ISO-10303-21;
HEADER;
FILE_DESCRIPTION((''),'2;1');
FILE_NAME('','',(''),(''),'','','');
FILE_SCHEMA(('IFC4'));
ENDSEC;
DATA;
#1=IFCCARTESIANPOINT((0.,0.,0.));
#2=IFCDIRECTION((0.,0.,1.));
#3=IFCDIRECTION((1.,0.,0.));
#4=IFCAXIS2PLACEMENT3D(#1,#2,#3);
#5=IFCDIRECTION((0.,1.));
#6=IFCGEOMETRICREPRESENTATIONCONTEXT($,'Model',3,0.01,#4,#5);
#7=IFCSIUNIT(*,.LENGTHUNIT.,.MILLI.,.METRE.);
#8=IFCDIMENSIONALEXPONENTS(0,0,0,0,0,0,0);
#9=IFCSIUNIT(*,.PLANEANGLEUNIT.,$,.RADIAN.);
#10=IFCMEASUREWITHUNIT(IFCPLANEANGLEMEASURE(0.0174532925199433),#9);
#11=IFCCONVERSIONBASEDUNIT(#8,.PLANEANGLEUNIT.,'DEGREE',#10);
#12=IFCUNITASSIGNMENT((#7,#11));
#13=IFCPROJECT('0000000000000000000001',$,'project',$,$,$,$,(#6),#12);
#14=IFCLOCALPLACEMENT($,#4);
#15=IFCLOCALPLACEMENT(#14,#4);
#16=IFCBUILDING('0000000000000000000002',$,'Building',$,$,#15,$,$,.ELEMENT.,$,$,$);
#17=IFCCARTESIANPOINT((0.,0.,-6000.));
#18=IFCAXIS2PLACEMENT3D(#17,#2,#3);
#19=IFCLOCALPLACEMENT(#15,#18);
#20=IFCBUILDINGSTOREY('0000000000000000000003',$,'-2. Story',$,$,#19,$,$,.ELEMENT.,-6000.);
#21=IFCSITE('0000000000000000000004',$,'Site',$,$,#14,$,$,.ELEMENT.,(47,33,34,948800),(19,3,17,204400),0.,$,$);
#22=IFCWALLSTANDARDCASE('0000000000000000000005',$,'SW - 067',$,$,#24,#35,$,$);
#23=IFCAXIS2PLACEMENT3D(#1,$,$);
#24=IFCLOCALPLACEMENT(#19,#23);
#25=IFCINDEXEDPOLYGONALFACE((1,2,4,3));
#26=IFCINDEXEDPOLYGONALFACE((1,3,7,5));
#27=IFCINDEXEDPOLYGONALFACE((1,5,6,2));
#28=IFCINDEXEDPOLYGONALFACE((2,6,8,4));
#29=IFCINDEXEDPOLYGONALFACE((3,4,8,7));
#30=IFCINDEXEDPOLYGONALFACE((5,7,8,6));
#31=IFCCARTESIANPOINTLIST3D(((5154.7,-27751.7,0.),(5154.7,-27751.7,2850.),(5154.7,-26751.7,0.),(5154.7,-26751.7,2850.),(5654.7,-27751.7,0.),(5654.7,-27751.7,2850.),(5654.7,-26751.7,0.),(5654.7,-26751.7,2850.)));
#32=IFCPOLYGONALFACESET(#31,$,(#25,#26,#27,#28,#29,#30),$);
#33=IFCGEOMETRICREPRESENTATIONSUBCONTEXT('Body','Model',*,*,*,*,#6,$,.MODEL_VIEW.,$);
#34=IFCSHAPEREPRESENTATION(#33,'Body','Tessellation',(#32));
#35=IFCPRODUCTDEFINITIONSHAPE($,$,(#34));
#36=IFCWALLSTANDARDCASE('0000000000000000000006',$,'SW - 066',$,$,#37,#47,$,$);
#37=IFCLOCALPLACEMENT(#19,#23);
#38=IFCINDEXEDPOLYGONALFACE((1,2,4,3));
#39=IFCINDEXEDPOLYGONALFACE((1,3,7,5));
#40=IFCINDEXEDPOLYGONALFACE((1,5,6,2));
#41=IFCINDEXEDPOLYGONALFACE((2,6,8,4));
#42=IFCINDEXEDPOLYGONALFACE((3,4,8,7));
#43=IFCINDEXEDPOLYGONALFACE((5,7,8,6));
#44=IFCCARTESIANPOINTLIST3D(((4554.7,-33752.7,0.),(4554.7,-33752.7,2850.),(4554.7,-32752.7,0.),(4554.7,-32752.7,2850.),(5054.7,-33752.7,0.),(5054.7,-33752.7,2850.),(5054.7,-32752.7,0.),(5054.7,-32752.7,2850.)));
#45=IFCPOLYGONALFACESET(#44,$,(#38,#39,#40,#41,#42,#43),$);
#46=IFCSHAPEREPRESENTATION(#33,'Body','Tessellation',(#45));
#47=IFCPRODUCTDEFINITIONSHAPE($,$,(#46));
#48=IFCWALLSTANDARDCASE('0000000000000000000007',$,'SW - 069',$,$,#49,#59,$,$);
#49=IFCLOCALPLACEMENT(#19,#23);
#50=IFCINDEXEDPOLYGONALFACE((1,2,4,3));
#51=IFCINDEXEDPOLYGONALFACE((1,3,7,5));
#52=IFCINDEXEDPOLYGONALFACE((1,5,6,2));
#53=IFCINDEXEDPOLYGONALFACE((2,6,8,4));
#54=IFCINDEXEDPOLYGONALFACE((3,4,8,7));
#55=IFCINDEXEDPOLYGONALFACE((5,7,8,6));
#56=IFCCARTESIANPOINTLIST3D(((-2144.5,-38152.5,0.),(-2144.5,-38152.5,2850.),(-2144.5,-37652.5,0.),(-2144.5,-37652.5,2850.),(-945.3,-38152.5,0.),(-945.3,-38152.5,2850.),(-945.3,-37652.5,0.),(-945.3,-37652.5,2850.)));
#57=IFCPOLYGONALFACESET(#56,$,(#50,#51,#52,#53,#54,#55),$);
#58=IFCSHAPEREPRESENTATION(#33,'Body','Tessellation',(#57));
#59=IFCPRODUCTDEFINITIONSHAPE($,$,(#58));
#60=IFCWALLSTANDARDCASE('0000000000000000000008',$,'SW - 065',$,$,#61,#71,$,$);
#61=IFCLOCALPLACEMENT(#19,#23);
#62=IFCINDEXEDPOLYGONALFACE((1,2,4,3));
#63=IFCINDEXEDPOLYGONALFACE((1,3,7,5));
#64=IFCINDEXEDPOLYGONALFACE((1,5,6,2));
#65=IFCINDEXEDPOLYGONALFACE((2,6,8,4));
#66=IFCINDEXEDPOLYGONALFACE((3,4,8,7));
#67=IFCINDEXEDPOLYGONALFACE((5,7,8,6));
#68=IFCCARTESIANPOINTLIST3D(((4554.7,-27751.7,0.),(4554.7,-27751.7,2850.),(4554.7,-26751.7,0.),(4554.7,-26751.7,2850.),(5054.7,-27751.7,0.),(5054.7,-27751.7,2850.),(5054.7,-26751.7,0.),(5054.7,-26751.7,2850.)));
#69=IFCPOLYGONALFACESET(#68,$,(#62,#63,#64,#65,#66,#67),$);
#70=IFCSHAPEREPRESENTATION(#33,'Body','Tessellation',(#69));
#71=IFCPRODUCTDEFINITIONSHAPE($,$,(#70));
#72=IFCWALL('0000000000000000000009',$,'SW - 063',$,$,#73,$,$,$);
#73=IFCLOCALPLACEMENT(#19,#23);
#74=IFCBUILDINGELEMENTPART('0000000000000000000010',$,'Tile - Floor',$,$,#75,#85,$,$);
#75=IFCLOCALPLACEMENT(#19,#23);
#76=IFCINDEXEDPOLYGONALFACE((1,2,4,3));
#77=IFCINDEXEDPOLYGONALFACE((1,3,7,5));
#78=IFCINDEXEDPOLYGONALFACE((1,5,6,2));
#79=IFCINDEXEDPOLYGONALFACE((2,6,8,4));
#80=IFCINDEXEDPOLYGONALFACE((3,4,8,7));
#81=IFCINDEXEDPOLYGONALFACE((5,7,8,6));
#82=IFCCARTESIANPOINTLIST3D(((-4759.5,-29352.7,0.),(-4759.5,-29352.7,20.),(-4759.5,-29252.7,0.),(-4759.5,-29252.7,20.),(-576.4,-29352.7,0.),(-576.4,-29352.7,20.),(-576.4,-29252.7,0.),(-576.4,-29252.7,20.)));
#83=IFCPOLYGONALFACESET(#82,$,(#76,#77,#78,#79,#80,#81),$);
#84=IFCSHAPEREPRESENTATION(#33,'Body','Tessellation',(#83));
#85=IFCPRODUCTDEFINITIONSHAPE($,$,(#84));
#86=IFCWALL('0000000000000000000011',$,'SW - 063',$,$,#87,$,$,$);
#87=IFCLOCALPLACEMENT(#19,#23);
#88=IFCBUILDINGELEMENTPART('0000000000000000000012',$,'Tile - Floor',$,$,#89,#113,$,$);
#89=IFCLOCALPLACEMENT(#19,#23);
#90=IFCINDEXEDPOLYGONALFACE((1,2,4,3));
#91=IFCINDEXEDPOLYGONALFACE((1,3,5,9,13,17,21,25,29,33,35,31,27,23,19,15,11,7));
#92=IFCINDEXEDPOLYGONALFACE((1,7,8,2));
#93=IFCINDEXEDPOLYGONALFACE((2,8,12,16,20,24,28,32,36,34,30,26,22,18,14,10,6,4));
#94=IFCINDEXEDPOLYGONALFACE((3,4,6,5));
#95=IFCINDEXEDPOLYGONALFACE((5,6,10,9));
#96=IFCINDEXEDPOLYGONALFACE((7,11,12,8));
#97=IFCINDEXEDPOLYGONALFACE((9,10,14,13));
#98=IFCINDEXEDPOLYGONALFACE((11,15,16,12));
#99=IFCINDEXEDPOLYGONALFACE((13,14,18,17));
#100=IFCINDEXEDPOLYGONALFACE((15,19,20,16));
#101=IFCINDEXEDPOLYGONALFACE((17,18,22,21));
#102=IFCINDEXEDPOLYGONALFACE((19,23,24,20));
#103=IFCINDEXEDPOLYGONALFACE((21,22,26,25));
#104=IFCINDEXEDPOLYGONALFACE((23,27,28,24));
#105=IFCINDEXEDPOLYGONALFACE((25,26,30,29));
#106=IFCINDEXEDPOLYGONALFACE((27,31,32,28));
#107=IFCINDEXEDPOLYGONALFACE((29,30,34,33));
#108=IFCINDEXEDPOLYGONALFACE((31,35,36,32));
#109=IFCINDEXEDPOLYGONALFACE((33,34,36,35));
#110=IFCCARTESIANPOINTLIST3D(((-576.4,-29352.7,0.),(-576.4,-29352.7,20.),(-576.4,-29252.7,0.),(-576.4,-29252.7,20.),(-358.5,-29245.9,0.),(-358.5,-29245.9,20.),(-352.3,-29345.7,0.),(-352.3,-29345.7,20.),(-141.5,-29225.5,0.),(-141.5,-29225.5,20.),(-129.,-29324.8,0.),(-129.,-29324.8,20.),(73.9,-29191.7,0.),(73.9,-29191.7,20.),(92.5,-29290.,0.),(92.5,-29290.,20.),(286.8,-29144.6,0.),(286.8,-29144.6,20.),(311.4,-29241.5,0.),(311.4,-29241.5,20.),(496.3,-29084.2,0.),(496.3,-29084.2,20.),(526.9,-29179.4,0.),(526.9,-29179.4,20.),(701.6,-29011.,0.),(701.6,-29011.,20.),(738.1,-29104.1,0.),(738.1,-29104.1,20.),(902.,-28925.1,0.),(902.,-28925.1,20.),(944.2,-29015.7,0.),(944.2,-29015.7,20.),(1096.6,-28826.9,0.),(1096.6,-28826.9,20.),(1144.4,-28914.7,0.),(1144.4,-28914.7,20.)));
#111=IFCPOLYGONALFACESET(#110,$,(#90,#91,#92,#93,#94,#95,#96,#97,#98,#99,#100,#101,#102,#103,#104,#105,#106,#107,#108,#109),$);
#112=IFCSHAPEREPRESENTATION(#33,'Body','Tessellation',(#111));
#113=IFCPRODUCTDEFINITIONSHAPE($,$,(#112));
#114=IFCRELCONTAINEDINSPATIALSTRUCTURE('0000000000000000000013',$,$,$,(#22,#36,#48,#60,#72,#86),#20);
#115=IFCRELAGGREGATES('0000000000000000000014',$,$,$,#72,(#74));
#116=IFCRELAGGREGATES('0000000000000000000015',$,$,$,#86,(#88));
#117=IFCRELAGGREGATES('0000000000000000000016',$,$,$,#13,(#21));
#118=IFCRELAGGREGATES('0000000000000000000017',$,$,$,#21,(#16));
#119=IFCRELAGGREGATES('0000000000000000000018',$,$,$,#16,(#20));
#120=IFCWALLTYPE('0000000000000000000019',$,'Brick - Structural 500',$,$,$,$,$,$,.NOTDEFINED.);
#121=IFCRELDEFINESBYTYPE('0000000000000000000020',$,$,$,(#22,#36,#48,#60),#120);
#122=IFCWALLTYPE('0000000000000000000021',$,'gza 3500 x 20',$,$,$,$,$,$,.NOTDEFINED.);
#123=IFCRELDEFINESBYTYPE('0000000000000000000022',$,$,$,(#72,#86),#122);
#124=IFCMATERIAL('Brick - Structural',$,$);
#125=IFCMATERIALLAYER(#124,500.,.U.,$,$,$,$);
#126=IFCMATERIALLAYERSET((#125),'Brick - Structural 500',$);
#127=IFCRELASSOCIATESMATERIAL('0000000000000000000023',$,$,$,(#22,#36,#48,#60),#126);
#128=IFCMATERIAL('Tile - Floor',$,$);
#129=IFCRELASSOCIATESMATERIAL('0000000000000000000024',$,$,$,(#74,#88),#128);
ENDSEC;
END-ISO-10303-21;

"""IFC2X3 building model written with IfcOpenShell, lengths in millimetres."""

from ifc_helpers import new_model, entity, si_unit, converted_unit, direction, frame, origin_with_axes, place, context, subcontext, project, spatial, polyline, outline, extrude, material, layer, layer_set, layer_usage, type_object, element, aggregate, save


model = new_model("IFC2X3")

# Units and contexts
model_context = context("Model", 3, precision=0.01, world=origin_with_axes(), true_north=direction((0.0, 1.0)))
body_context = subcontext(model_context, "Body", "Model", "MODEL_VIEW")
ifc_project = project(units=[si_unit("LENGTHUNIT", "METRE", prefix="MILLI"), converted_unit("PLANEANGLEUNIT", "DEGREE", entity("IfcPlaneAngleMeasure", 0.0174532925199433), si_unit("PLANEANGLEUNIT", "RADIAN"), dimensions=[0, 0, 0, 0, 0, 0, 0])], contexts=[model_context])

# Site, building, storey
site_placement = place(None, origin_with_axes())
site = spatial("IfcSite", under=ifc_project, at=site_placement, Name="Site", CompositionType="ELEMENT", RefLatitude=(47, 33, 34, 948800), RefLongitude=(19, 3, 17, 204400), RefElevation=0.0)
building_placement = place(site_placement, origin_with_axes())
building = spatial("IfcBuilding", under=site, at=building_placement, Name="Building", CompositionType="ELEMENT")
storey_placement = place(building_placement, frame((0.0, 0.0, -6000.0), z_axis=(0.0, 0.0, 1.0), x_axis=(1.0, 0.0, 0.0)))
storey = spatial("IfcBuildingStorey", under=building, at=storey_placement, Name="-2. Story", CompositionType="ELEMENT", Elevation=-6000.0)

# Shared definitions
ifc_material_1 = material(Name="Brick - Structural")

# Walls
ifc_layer_1 = layer(ifc_material_1, 500.0, ventilated="UNKNOWN")
ifc_layer_set_1 = layer_set([ifc_layer_1], Name="Brick - Structural 500")
wall_type_1 = type_object("IfcWallType", Name="Brick - Structural 500", PredefinedType="NOTDEFINED")
ifc_layer_usage_1 = layer_usage(ifc_layer_set_1, "AXIS2", "POSITIVE", 0.0)
wall_1_placement = place(storey_placement, frame((5154.7, -26751.7, 0.0), z_axis=(0.0, 0.0, 1.0), x_axis=(0.0, -1.0, 0.0)))
element("IfcWallStandardCase", 1, at=wall_1_placement, inside=storey, type_object=wall_type_1, material=ifc_layer_usage_1, Name="SW - 067", context=body_context, shape_type="SweptSolid", body=[
    extrude(outline(polyline([(0.0, 0.0), (1000.0, 0.0), (1000.0, 500.0), (0.0, 500.0), (0.0, 0.0)])), origin_with_axes(), (0.0, 0.0, 1.0), 2850.0),
])
ifc_layer_usage_2 = layer_usage(ifc_layer_set_1, "AXIS2", "POSITIVE", 0.0)
wall_2_placement = place(storey_placement, frame((5054.7, -33752.7, 0.0), z_axis=(0.0, 0.0, 1.0), x_axis=(0.0, 1.0, 0.0)))
element("IfcWallStandardCase", 2, at=wall_2_placement, inside=storey, type_object=wall_type_1, material=ifc_layer_usage_2, Name="SW - 066", context=body_context, shape_type="SweptSolid", body=[
    extrude(outline(polyline([(0.0, 0.0), (1000.0, 0.0), (1000.0, 500.0), (0.0, 500.0), (0.0, 0.0)])), origin_with_axes(), (0.0, 0.0, 1.0), 2850.0),
])
ifc_layer_usage_3 = layer_usage(ifc_layer_set_1, "AXIS2", "NEGATIVE", 0.0)
wall_3_placement = place(storey_placement, frame((-945.3, -38152.5, 0.0), z_axis=(0.0, 0.0, 1.0), x_axis=(-1.0, 0.0, 0.0)))
element("IfcWallStandardCase", 3, at=wall_3_placement, inside=storey, type_object=wall_type_1, material=ifc_layer_usage_3, Name="SW - 069", context=body_context, shape_type="SweptSolid", body=[
    extrude(outline(polyline([(0.0, -500.0), (1199.2, -500.0), (1199.2, 0.0), (0.0, 0.0), (0.0, -500.0)])), origin_with_axes(), (0.0, 0.0, 1.0), 2850.0),
])
ifc_layer_usage_4 = layer_usage(ifc_layer_set_1, "AXIS2", "POSITIVE", 0.0)
wall_4_placement = place(storey_placement, frame((5054.7, -27751.7, 0.0), z_axis=(0.0, 0.0, 1.0), x_axis=(0.0, 1.0, 0.0)))
element("IfcWallStandardCase", 4, at=wall_4_placement, inside=storey, type_object=wall_type_1, material=ifc_layer_usage_4, Name="SW - 065", context=body_context, shape_type="SweptSolid", body=[
    extrude(outline(polyline([(0.0, 0.0), (1000.0, 0.0), (1000.0, 500.0), (0.0, 500.0), (0.0, 0.0)])), origin_with_axes(), (0.0, 0.0, 1.0), 2850.0),
])

# Walls, building element parts
wall_type_2 = type_object("IfcWallType", Name="gza 3500 x 20", PredefinedType="NOTDEFINED")
wall_5_placement = place(storey_placement, frame((-576.4, -29252.7, 0.0), z_axis=(0.0, 0.0, 1.0), x_axis=(-1.0, 0.0, 0.0)))
wall_5 = element("IfcWall", 5, at=wall_5_placement, inside=storey, type_object=wall_type_2, Name="SW - 063")
ifc_material_2 = material(Name="Tile - Floor")
building_element_part_1_placement = place(wall_5_placement, origin_with_axes())
building_element_part_1 = element("IfcBuildingElementPart", 6, at=building_element_part_1_placement, material=ifc_material_2, Name="Tile - Floor", context=body_context, shape_type="SweptSolid", body=[
    extrude(outline(polyline([(100.0, 0.0), (100.0, 20.0), (0.0, 20.0), (0.0, 0.0), (100.0, 0.0)])), frame((0.0, 0.0, 0.0), z_axis=(1.0, 0.0, 0.0), x_axis=(0.0, 1.0, 0.0)), (0.0, 0.0, 1.0), 4183.0),
])
aggregate(wall_5, [building_element_part_1])
wall_6_placement = place(storey_placement, frame((-576.4, -29252.7, 0.0), z_axis=(0.0, 0.0, 1.0), x_axis=(1.0, 0.0, 0.0)))
wall_6 = element("IfcWall", 7, at=wall_6_placement, inside=storey, type_object=wall_type_2, Name="SW - 063")
building_element_part_2_placement = place(wall_6_placement, origin_with_axes())
cartesian_point_1 = entity("IfcCartesianPoint", [100.0, 0.0])
building_element_part_2 = element("IfcBuildingElementPart", 8, at=building_element_part_2_placement, material=ifc_material_2, Name="Tile - Floor", context=body_context, shape_type="SweptSolid", body=[
    entity("IfcRevolvedAreaSolid", entity("IfcArbitraryClosedProfileDef", "AREA", None, entity("IfcPolyline", [cartesian_point_1, entity("IfcCartesianPoint", [100.0, 20.0]), entity("IfcCartesianPoint", [0.0, 20.0]), entity("IfcCartesianPoint", [0.0, 0.0]), cartesian_point_1])), entity("IfcAxis2Placement3D", entity("IfcCartesianPoint", [0.0, 0.0, 0.0]), entity("IfcDirection", [-1.0, 0.0, 0.0]), entity("IfcDirection", [0.0, -1.0, 0.0])), entity("IfcAxis1Placement", entity("IfcCartesianPoint", [-3500.0, 0.0, 0.0]), entity("IfcDirection", [0.0, 1.0, 0.0])), 28.555603),
])
aggregate(wall_6, [building_element_part_2])

save(model, "model.ifc")
